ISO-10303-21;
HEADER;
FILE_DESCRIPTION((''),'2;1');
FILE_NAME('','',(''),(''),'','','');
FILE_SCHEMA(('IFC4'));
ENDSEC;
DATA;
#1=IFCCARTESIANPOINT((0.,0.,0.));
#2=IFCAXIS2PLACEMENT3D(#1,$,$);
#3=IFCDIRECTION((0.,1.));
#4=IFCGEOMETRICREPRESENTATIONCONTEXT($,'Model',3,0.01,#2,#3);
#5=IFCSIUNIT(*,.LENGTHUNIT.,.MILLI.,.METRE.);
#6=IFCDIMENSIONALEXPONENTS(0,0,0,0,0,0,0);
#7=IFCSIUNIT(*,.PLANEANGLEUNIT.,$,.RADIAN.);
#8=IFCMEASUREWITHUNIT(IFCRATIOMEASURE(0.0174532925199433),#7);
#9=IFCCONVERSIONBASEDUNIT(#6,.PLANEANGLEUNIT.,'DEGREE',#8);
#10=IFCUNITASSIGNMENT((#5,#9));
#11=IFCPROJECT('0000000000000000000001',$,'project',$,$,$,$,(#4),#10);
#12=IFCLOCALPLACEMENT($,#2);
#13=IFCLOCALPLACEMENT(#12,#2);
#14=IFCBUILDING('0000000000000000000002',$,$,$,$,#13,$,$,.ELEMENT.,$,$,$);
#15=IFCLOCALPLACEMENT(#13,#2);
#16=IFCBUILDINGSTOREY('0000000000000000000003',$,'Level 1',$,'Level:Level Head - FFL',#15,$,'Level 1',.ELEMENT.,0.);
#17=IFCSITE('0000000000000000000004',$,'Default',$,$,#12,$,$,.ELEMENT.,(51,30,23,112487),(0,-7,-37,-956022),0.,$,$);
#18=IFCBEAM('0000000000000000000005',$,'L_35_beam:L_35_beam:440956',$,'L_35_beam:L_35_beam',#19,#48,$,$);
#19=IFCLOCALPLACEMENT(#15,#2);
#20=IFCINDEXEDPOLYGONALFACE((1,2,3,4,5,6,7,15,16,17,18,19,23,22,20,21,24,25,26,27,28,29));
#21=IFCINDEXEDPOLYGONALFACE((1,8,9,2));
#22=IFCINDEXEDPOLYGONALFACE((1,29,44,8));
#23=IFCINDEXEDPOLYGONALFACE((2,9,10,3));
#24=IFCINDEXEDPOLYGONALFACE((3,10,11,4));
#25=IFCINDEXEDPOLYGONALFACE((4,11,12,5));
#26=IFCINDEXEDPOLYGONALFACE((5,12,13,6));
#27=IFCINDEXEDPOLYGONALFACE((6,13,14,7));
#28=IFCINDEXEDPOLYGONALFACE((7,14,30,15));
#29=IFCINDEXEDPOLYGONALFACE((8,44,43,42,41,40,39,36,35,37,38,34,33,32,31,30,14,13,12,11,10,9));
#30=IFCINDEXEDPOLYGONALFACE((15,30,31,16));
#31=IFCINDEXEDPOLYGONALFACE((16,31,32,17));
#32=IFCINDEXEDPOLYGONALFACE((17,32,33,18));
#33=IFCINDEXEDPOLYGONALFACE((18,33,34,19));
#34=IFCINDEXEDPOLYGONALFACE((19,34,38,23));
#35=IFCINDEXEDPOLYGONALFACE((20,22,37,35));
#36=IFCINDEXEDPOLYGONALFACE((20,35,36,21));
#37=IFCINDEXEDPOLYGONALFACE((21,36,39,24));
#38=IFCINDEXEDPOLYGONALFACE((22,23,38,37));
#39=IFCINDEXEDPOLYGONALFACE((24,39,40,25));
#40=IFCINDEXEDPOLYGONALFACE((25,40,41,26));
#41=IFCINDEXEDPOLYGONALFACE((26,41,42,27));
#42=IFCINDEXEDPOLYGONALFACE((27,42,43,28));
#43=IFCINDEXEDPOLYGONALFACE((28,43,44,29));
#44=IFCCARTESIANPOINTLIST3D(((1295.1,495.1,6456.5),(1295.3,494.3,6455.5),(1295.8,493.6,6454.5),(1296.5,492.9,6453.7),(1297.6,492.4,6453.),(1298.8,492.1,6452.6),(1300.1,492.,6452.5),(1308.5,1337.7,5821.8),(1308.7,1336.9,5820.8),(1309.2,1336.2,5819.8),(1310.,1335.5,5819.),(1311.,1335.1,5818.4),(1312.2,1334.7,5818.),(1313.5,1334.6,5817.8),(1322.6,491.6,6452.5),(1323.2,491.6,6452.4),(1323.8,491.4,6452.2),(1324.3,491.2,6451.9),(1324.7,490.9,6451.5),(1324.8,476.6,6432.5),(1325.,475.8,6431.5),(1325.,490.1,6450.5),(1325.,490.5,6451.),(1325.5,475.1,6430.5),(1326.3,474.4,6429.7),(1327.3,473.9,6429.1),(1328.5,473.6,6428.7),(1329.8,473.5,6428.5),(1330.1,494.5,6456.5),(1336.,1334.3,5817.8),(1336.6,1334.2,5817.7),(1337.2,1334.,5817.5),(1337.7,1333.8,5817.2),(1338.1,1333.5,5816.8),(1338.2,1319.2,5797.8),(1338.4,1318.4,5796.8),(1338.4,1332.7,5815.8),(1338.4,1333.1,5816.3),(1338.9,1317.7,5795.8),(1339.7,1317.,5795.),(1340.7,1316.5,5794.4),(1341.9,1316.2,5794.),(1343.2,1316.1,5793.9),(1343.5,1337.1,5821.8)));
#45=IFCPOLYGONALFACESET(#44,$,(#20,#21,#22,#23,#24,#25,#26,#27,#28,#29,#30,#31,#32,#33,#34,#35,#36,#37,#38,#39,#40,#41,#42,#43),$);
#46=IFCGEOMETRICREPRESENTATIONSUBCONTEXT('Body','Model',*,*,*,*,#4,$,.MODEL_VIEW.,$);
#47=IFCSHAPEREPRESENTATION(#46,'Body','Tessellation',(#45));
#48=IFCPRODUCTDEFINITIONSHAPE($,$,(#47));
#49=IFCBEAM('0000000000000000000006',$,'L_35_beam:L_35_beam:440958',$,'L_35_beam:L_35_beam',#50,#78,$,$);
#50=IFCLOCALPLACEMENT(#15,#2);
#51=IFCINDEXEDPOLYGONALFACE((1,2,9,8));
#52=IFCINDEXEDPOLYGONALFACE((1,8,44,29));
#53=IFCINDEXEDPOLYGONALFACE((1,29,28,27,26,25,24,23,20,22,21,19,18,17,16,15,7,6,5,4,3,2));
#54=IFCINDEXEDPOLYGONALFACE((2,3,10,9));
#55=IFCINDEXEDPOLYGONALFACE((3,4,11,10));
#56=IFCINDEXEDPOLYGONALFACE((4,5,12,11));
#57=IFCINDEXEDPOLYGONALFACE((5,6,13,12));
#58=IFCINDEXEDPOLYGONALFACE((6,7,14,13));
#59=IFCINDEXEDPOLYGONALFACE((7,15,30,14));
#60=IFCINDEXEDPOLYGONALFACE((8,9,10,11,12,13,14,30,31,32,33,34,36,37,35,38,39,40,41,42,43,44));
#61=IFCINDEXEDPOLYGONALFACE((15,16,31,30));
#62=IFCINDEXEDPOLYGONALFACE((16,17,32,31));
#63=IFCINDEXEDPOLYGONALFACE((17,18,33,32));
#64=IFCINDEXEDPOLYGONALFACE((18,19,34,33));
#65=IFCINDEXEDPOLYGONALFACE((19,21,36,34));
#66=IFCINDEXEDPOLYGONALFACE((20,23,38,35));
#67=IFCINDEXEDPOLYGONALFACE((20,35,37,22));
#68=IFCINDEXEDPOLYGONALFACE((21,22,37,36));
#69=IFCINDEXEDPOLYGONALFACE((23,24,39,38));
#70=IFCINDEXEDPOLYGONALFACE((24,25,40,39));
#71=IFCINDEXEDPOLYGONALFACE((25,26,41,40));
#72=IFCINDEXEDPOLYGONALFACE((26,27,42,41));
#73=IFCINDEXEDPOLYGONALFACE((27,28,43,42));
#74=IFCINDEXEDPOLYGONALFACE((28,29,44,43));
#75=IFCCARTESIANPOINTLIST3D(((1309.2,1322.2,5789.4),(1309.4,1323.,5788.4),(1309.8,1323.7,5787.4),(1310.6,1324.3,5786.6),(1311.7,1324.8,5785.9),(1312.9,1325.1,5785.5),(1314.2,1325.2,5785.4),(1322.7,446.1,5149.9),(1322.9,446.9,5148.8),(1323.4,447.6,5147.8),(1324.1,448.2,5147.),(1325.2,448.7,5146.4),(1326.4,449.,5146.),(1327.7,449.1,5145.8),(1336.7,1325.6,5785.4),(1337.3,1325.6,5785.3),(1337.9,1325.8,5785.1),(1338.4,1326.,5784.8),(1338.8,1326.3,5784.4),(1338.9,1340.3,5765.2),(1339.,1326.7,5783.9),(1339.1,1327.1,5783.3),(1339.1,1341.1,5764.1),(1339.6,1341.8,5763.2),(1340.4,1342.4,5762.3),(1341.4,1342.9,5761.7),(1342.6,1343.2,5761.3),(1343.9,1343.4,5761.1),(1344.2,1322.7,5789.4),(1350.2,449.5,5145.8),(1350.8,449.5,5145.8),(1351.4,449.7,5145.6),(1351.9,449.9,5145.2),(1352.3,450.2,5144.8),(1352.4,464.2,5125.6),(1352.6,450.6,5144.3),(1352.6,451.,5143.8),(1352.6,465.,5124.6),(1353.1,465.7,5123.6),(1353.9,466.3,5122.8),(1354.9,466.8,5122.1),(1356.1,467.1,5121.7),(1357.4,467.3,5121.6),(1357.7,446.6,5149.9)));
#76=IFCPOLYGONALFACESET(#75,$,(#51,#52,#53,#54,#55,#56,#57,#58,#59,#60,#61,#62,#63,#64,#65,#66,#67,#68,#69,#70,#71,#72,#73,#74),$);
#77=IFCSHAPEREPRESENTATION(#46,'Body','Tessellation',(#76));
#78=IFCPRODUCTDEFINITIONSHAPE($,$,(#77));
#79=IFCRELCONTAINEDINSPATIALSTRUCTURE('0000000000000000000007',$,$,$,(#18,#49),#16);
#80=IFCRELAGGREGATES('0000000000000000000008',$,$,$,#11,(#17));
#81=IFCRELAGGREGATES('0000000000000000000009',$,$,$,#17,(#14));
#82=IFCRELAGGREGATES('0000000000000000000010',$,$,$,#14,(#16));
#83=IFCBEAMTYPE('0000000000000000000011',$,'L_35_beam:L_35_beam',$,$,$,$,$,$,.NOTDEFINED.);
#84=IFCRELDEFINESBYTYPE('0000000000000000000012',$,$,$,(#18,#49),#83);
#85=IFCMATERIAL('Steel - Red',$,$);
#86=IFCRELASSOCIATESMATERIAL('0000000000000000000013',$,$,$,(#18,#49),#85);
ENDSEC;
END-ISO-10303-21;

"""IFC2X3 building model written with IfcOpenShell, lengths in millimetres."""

from ifc_helpers import new_model, entity, si_unit, converted_unit, direction, frame, frame_2d, origin, place, context, subcontext, project, spatial, polyline, circle_curve, parameter, trimmed, segment, composite_curve, outline, extrude, material, type_object, element, save


model = new_model("IFC2X3")

# Units and contexts
model_context = context("Model", 3, precision=0.01, world=origin(), true_north=direction((0.0, 1.0)))
body_context = subcontext(model_context, "Body", "Model", "MODEL_VIEW")
ifc_project = project(units=[si_unit("LENGTHUNIT", "METRE", prefix="MILLI"), converted_unit("PLANEANGLEUNIT", "DEGREE", entity("IfcRatioMeasure", 0.0174532925199433), si_unit("PLANEANGLEUNIT", "RADIAN"), dimensions=[0, 0, 0, 0, 0, 0, 0])], contexts=[model_context])

# Site, building, storey
site_placement = place(None, origin())
site = spatial("IfcSite", under=ifc_project, at=site_placement, Name="Default", CompositionType="ELEMENT", RefLatitude=(51, 30, 23, 112487), RefLongitude=(0, -7, -37, -956022), RefElevation=0.0)
building_placement = place(site_placement, origin())
building = spatial("IfcBuilding", under=site, at=building_placement, CompositionType="ELEMENT")
storey_placement = place(building_placement, origin())
storey = spatial("IfcBuildingStorey", under=building, at=storey_placement, Name="Level 1", ObjectType="Level:Level Head - FFL", LongName="Level 1", CompositionType="ELEMENT", Elevation=0.0)

# Beams
ifc_material_1 = material(Name="Steel - Red")
beam_type_1 = type_object("IfcBeamType", Name="L_35_beam:L_35_beam", PredefinedType="NOTDEFINED")
beam_1_placement = place(storey_placement, frame((1351.8, 1351.7, 5788.8), z_axis=(0.009574, 0.60153, 0.798793), x_axis=(-0.012712, -0.798692, 0.601606)))
element("IfcBeam", 1, at=beam_1_placement, inside=storey, type_object=beam_type_1, material=ifc_material_1, Name="L_35_beam:L_35_beam:440956", ObjectType="L_35_beam:L_35_beam", context=body_context, shape_type="SweptSolid", body=[
    extrude(outline(composite_curve([segment(polyline([(-23.2, -11.8), (11.8, -11.8)]), True, "CONTINUOUS"), segment(polyline([(11.8, -11.8), (11.8, 23.2)]), True, "CONTINUOUS"), segment(trimmed(circle_curve(frame_2d((11.8, 18.2), x_axis=(0.0, 1.0)), 5.0), [parameter(0.0)], [parameter(90.0)], True, "PARAMETER"), True, "CONTINUOUS"), segment(polyline([(6.8, 18.2), (6.8, -4.3)]), True, "CONTINUOUS"), segment(trimmed(circle_curve(frame_2d((4.3, -4.3), x_axis=(1.0, 0.0)), 2.5), [parameter(270.0)], [parameter(0.0)], True, "PARAMETER"), False, "CONTINUOUS"), segment(polyline([(4.3, -6.8), (-18.2, -6.8)]), True, "CONTINUOUS"), segment(trimmed(circle_curve(frame_2d((-18.2, -11.8), x_axis=(0.0, 1.0)), 5.0), [parameter(0.0)], [parameter(90.0)], True, "PARAMETER"), True, "CONTINUOUS")], self_intersect=False)), frame((31.6, -19.8, 5.7), z_axis=(1.0, 0.0, 0.0), x_axis=(0.0, 0.0, 1.0)), (0.0, 0.0, 1.0), 1055.0),
])
beam_2_placement = place(storey_placement, frame((1351.8, 1351.7, 5788.8), z_axis=(0.009093, -0.589494, 0.807721), x_axis=(0.012457, -0.807625, -0.589564)))
element("IfcBeam", 2, at=beam_2_placement, inside=storey, type_object=beam_type_1, material=ifc_material_1, Name="L_35_beam:L_35_beam:440958", ObjectType="L_35_beam:L_35_beam", context=body_context, shape_type="SweptSolid", body=[
    extrude(outline(composite_curve([segment(polyline([(-23.2, -11.8), (11.8, -11.8)]), True, "CONTINUOUS"), segment(polyline([(11.8, -11.8), (11.8, 23.2)]), True, "CONTINUOUS"), segment(trimmed(circle_curve(frame_2d((11.8, 18.2), x_axis=(0.0, 1.0)), 5.0), [parameter(0.0)], [parameter(90.0)], True, "PARAMETER"), True, "CONTINUOUS"), segment(polyline([(6.8, 18.2), (6.8, -4.3)]), True, "CONTINUOUS"), segment(trimmed(circle_curve(frame_2d((4.3, -4.3), x_axis=(1.0, 0.0)), 2.5), [parameter(270.0)], [parameter(0.0)], True, "PARAMETER"), False, "CONTINUOUS"), segment(polyline([(4.3, -6.8), (-18.2, -6.8)]), True, "CONTINUOUS"), segment(trimmed(circle_curve(frame_2d((-18.2, -11.8), x_axis=(0.0, 1.0)), 5.0), [parameter(0.0)], [parameter(90.0)], True, "PARAMETER"), True, "CONTINUOUS")], self_intersect=False)), frame((23.0, -19.8, 5.7), z_axis=(1.0, 0.0, 0.0), x_axis=(0.0, 0.0, 1.0)), (0.0, 0.0, 1.0), 1084.8),
])

save(model, "model.ifc")
